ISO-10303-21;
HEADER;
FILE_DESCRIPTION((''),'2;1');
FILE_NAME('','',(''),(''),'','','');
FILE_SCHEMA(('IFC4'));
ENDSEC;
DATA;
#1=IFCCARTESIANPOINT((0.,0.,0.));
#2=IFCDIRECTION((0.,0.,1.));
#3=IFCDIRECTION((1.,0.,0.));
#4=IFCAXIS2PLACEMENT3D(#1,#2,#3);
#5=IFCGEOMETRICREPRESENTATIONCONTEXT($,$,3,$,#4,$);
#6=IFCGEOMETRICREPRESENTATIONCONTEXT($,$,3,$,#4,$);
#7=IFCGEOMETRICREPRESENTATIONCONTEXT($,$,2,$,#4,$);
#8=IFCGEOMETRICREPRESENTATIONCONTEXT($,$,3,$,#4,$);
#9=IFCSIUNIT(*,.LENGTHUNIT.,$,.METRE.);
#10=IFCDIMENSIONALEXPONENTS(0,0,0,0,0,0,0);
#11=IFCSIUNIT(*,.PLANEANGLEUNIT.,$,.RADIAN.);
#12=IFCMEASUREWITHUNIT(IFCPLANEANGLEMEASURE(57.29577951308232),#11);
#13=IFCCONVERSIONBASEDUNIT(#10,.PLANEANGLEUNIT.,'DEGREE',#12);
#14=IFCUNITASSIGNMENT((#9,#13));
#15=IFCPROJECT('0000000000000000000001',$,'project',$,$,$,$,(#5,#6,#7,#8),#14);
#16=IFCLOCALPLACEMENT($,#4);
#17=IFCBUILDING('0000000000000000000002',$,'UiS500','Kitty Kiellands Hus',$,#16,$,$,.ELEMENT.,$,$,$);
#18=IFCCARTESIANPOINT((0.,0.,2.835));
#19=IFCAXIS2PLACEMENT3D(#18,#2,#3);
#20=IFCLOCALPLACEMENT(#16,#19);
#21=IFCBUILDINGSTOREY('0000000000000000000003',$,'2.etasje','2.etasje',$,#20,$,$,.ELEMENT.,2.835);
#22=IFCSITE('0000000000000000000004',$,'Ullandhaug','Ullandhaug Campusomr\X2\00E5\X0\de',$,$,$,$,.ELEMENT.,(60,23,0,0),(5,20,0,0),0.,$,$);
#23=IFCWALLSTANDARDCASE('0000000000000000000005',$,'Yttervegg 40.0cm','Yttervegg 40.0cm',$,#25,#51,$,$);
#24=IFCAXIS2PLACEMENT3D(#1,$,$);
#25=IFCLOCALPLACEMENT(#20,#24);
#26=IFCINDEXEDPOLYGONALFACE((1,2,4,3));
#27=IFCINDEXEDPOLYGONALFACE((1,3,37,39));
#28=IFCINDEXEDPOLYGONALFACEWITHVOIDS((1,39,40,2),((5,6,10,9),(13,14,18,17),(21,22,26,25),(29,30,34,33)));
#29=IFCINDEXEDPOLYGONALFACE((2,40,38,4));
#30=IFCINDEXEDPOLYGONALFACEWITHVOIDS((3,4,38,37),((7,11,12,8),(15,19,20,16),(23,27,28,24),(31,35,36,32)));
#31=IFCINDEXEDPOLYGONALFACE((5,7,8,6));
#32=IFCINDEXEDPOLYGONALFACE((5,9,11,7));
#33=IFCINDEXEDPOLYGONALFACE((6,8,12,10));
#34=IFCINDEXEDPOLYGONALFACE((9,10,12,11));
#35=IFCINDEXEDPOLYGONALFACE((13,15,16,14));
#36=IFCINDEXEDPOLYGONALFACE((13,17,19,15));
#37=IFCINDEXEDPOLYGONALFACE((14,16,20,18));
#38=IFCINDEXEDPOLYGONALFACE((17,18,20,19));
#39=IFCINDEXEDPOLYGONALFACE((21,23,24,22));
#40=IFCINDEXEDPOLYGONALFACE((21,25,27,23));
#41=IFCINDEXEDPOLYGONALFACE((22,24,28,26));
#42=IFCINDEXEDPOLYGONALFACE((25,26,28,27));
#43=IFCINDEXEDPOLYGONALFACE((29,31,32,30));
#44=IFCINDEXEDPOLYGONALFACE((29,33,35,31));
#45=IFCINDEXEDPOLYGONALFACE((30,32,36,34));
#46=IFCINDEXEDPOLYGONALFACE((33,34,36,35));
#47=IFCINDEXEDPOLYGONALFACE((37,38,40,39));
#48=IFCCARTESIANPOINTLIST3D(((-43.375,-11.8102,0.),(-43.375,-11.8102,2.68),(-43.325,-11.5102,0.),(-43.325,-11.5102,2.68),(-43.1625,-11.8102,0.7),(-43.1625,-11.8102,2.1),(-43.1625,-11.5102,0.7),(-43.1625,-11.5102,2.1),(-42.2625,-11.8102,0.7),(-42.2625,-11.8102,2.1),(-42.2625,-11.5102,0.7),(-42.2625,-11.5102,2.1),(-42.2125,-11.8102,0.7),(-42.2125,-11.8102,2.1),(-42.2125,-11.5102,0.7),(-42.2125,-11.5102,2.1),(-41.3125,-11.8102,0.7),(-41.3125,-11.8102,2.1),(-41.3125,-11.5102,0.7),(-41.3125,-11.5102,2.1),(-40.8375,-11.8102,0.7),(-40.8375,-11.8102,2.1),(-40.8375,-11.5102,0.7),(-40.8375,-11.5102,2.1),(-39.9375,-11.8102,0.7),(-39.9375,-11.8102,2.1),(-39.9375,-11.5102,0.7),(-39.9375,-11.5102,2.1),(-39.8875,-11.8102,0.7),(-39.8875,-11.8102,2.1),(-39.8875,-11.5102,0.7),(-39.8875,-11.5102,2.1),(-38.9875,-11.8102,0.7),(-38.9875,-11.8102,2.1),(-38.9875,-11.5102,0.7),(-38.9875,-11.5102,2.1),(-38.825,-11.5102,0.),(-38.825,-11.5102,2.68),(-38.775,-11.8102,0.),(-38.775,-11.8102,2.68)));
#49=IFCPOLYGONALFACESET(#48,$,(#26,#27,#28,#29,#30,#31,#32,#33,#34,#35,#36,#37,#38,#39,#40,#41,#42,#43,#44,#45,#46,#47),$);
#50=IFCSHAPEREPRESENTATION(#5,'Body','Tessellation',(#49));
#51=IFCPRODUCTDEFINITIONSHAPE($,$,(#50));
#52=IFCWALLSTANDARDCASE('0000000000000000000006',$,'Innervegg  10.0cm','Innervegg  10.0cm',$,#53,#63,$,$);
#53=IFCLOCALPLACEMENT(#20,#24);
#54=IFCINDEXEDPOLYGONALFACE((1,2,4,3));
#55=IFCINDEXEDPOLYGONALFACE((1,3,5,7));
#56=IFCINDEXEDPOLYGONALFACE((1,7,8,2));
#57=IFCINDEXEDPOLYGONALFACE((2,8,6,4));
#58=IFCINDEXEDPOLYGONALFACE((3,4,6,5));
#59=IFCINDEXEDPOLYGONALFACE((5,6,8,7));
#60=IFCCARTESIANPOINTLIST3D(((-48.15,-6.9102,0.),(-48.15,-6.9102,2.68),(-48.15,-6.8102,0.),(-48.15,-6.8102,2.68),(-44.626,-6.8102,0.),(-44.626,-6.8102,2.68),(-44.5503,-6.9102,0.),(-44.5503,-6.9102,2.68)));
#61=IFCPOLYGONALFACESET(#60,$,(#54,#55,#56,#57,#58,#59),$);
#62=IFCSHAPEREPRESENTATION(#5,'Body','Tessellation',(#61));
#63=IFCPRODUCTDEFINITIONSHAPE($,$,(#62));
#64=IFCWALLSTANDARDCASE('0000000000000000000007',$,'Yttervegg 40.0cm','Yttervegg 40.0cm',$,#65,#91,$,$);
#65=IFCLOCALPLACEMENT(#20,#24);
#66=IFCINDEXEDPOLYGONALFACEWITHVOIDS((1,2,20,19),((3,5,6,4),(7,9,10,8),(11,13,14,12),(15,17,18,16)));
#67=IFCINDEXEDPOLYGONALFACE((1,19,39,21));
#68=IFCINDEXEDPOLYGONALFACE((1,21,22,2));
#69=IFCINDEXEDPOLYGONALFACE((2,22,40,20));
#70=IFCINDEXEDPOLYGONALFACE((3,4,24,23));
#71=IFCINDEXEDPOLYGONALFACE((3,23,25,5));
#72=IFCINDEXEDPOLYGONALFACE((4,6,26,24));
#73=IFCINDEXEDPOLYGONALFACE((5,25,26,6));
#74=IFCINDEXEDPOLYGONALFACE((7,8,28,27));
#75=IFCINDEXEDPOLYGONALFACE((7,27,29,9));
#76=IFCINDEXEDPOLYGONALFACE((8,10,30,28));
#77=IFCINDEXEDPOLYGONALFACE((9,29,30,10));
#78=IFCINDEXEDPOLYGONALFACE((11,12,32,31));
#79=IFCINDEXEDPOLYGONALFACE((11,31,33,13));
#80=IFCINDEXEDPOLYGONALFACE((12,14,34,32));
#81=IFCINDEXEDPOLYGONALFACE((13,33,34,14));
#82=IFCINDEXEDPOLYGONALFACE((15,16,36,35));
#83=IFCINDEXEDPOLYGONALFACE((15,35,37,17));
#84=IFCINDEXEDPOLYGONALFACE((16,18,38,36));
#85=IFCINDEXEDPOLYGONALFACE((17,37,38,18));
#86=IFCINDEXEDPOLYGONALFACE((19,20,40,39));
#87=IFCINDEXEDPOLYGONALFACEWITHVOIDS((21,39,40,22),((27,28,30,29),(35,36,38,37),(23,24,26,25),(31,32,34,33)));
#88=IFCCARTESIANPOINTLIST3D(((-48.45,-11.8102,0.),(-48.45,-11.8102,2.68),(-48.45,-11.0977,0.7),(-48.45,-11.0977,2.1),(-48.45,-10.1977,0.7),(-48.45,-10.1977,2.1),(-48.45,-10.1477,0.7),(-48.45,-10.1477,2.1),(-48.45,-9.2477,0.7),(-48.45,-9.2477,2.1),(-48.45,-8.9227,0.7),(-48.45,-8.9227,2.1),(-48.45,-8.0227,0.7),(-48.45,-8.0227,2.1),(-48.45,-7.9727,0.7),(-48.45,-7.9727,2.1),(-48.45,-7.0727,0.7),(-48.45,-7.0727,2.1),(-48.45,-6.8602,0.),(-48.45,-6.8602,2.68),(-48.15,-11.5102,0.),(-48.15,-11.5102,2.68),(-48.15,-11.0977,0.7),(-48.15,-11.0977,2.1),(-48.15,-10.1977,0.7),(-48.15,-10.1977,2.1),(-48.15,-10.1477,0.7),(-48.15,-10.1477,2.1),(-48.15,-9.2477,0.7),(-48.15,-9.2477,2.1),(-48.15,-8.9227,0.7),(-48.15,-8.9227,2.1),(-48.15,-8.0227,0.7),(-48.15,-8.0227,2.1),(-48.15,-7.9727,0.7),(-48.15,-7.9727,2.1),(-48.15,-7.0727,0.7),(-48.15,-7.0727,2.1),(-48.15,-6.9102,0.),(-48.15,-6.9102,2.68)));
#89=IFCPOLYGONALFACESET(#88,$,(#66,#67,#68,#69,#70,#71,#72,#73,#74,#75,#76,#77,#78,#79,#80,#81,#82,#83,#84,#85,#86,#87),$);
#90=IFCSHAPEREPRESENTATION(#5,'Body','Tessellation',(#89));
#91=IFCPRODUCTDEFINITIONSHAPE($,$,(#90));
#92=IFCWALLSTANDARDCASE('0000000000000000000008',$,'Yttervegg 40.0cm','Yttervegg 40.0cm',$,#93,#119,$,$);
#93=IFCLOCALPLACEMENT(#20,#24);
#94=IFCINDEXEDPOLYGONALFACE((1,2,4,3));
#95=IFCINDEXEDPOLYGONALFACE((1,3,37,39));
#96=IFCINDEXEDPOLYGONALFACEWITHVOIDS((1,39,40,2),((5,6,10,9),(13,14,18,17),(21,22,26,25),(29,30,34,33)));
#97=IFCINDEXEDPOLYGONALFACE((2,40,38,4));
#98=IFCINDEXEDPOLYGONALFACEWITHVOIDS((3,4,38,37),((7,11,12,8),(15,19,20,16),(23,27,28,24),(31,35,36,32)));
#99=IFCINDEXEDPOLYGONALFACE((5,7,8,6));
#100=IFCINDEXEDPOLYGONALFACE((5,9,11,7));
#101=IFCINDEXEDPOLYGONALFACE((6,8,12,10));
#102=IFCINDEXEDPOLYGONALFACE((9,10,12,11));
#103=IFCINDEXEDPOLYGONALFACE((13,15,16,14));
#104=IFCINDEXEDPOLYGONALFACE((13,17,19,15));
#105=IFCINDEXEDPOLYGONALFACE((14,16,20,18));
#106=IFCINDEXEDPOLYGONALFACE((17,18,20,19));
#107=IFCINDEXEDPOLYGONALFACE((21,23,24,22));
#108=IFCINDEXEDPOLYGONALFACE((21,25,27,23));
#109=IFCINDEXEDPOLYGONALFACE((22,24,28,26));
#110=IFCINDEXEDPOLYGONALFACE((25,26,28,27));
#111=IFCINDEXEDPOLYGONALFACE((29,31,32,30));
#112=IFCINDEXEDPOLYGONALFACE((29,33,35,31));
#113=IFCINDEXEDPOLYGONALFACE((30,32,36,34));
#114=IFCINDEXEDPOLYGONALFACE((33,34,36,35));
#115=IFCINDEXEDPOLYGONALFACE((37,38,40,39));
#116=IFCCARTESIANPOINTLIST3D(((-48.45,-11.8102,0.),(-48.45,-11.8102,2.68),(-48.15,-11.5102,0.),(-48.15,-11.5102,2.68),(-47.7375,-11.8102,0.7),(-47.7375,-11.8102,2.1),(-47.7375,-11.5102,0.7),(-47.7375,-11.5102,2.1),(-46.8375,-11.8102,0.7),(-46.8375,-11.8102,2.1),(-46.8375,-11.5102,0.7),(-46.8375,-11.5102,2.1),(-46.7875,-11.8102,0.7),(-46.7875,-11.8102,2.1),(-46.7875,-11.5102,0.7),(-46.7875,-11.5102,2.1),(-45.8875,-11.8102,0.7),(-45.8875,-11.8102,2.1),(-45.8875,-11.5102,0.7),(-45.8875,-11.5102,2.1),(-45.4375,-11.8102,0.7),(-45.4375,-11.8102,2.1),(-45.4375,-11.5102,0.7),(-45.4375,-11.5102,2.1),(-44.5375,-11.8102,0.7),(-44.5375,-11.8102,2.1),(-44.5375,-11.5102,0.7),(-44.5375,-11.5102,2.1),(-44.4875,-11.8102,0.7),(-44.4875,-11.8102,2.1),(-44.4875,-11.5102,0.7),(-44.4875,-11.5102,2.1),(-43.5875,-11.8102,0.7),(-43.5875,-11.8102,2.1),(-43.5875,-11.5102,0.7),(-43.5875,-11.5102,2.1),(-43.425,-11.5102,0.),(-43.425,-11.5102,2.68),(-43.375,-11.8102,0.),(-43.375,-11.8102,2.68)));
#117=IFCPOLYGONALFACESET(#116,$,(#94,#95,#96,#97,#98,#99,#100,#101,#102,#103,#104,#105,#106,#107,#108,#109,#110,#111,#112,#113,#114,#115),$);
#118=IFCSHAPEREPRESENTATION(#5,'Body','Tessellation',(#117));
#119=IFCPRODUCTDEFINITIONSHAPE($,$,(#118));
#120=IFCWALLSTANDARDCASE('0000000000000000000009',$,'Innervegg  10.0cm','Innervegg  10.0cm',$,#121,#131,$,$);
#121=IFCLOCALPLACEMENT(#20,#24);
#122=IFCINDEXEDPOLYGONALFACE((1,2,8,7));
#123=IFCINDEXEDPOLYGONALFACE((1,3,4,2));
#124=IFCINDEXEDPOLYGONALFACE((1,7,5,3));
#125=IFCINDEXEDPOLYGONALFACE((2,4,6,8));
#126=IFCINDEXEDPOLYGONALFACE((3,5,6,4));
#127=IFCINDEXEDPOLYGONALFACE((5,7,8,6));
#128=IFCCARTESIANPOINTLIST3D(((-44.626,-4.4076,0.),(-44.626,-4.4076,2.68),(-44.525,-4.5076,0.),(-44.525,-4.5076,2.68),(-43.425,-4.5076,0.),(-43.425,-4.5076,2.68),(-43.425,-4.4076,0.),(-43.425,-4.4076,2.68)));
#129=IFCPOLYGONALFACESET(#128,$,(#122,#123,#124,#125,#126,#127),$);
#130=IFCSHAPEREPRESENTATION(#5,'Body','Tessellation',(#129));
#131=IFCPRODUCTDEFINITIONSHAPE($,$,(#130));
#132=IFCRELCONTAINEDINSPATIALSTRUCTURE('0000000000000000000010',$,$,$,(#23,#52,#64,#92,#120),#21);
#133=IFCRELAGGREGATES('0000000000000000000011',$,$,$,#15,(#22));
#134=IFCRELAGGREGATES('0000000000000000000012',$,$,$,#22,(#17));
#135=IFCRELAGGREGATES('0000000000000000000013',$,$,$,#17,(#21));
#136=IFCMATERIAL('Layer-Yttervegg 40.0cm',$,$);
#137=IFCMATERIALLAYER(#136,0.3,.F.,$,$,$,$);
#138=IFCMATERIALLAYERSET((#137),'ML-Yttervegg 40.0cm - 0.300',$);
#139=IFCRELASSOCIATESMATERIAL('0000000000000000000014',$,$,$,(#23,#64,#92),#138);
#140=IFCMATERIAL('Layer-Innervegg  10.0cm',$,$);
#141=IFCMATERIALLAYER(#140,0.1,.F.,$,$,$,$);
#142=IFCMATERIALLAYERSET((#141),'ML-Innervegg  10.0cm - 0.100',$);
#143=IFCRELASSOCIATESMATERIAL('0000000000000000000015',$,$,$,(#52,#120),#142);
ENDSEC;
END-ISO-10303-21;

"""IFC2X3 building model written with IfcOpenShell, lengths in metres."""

from ifc_helpers import new_model, entity, si_unit, converted_unit, frame, origin_with_axes, place, context, project, spatial, polyline, outline, extrude, material, layer, layer_set, layer_usage, element, save


model = new_model("IFC2X3")

# Units and contexts
context_of_model_1 = context(None, 3, world=origin_with_axes())
context_of_model_2 = context(None, 3, world=origin_with_axes())
context_of_model_3 = context(None, 2, world=origin_with_axes())
context_of_model_4 = context(None, 3, world=origin_with_axes())
ifc_project = project(units=[si_unit("LENGTHUNIT", "METRE"), converted_unit("PLANEANGLEUNIT", "DEGREE", entity("IfcPlaneAngleMeasure", 57.29577951308232), si_unit("PLANEANGLEUNIT", "RADIAN"), dimensions=[0, 0, 0, 0, 0, 0, 0])], contexts=[context_of_model_1, context_of_model_2, context_of_model_3, context_of_model_4])

# Site, building, storey
site = spatial("IfcSite", under=ifc_project, Name="Ullandhaug", Description="Ullandhaug Campusområde", CompositionType="ELEMENT", RefLatitude=(60, 23, 0, 0), RefLongitude=(5, 20, 0, 0), RefElevation=0.0)
building_placement = place(None, origin_with_axes())
building = spatial("IfcBuilding", under=site, at=building_placement, Name="UiS500", Description="Kitty Kiellands Hus", CompositionType="ELEMENT")
storey_placement = place(building_placement, frame((0.0, 0.0, 2.835), z_axis=(0.0, 0.0, 1.0), x_axis=(1.0, 0.0, 0.0)))
storey = spatial("IfcBuildingStorey", under=building, at=storey_placement, Name="2.etasje", Description="2.etasje", CompositionType="ELEMENT", Elevation=2.835)

# Shared definitions
ifc_material_1 = material(Name="Layer-Innervegg  10.0cm")
ifc_layer_1 = layer(ifc_material_1, 0.1, ventilated=False)
ifc_layer_set_1 = layer_set([ifc_layer_1], Name="ML-Innervegg  10.0cm - 0.100")
ifc_layer_usage_1 = layer_usage(ifc_layer_set_1, "AXIS2", "POSITIVE", 0.0)

# Shared definitions
ifc_material_2 = material(Name="Layer-Yttervegg 40.0cm")
ifc_layer_2 = layer(ifc_material_2, 0.3, ventilated=False)
ifc_layer_set_2 = layer_set([ifc_layer_2], Name="ML-Yttervegg 40.0cm - 0.300")
ifc_layer_usage_2 = layer_usage(ifc_layer_set_2, "AXIS2", "POSITIVE", 0.0)

# Wall, openings
wall_1_placement = place(storey_placement, frame((-43.375, -11.8102, 0.0), z_axis=(0.0, 0.0, 1.0), x_axis=(1.0, 0.0, 0.0)))
wall_1 = element("IfcWallStandardCase", 1, at=wall_1_placement, inside=storey, material=ifc_layer_usage_2, Name="Yttervegg 40.0cm", Description="Yttervegg 40.0cm", context=context_of_model_1, shape_type="SweptSolid", body=[
    extrude(outline(polyline([(0.0, 0.0), (4.6, 0.0), (4.55, 0.3), (0.05, 0.3), (0.0, 0.0)])), origin_with_axes(), (0.0, 0.0, 1.0), 2.68),
])
opening_1_placement = place(wall_1_placement, frame((3.4875, 0.3, 0.7), z_axis=(0.0, 0.0, 1.0), x_axis=(1.0, 0.0, 0.0)))
element("IfcOpeningElement", 2, at=opening_1_placement, cuts=wall_1, context=context_of_model_1, shape_type="SweptSolid", body=[
    extrude(outline(polyline([(0.0, 0.0), (1.4, 0.0), (1.4, 0.9), (0.0, 0.9), (0.0, 0.0)])), frame((0.0, 0.0, 0.0), z_axis=(0.0, 1.0, 0.0), x_axis=(0.0, 0.0, 1.0)), (0.0, 0.0, -1.0), 0.3),
])
opening_2_placement = place(wall_1_placement, frame((2.5375, 0.3, 0.7), z_axis=(0.0, 0.0, 1.0), x_axis=(1.0, 0.0, 0.0)))
element("IfcOpeningElement", 3, at=opening_2_placement, cuts=wall_1, context=context_of_model_1, shape_type="SweptSolid", body=[
    extrude(outline(polyline([(0.0, 0.0), (1.4, 0.0), (1.4, 0.9), (0.0, 0.9), (0.0, 0.0)])), frame((0.0, 0.0, 0.0), z_axis=(0.0, 1.0, 0.0), x_axis=(0.0, 0.0, 1.0)), (0.0, 0.0, -1.0), 0.3),
])
opening_3_placement = place(wall_1_placement, frame((1.1625, 0.3, 0.7), z_axis=(0.0, 0.0, 1.0), x_axis=(1.0, 0.0, 0.0)))
element("IfcOpeningElement", 4, at=opening_3_placement, cuts=wall_1, context=context_of_model_1, shape_type="SweptSolid", body=[
    extrude(outline(polyline([(0.0, 0.0), (1.4, 0.0), (1.4, 0.9), (0.0, 0.9), (0.0, 0.0)])), frame((0.0, 0.0, 0.0), z_axis=(0.0, 1.0, 0.0), x_axis=(0.0, 0.0, 1.0)), (0.0, 0.0, -1.0), 0.3),
])
opening_4_placement = place(wall_1_placement, frame((0.2125, 0.3, 0.7), z_axis=(0.0, 0.0, 1.0), x_axis=(1.0, 0.0, 0.0)))
element("IfcOpeningElement", 5, at=opening_4_placement, cuts=wall_1, context=context_of_model_1, shape_type="SweptSolid", body=[
    extrude(outline(polyline([(0.0, 0.0), (1.4, 0.0), (1.4, 0.9), (0.0, 0.9), (0.0, 0.0)])), frame((0.0, 0.0, 0.0), z_axis=(0.0, 1.0, 0.0), x_axis=(0.0, 0.0, 1.0)), (0.0, 0.0, -1.0), 0.3),
])

# Wall
wall_2_placement = place(storey_placement, frame((-44.626, -6.8102, 0.0), z_axis=(0.0, 0.0, 1.0), x_axis=(-1.0, 0.0, 0.0)))
element("IfcWallStandardCase", 6, at=wall_2_placement, inside=storey, material=ifc_layer_usage_1, Name="Innervegg  10.0cm", Description="Innervegg  10.0cm", context=context_of_model_1, shape_type="SweptSolid", body=[
    extrude(outline(polyline([(0.0, 0.0), (3.524, 0.0), (3.524, 0.1), (-0.0758, 0.1), (0.0, 0.0)])), frame((0.0, 0.0, 0.0), z_axis=(0.0, 0.0, 1.0), x_axis=(1.0, 0.0, 0.0)), (0.0, 0.0, 1.0), 2.68),
])

# Walls, openings
wall_3_placement = place(storey_placement, frame((-48.45, -6.8602, 0.0), z_axis=(0.0, 0.0, 1.0), x_axis=(0.0, -1.0, 0.0)))
wall_3 = element("IfcWallStandardCase", 7, at=wall_3_placement, inside=storey, material=ifc_layer_usage_2, Name="Yttervegg 40.0cm", Description="Yttervegg 40.0cm", context=context_of_model_1, shape_type="SweptSolid", body=[
    extrude(outline(polyline([(0.0, 0.0), (4.95, 0.0), (4.65, 0.3), (0.05, 0.3), (0.0, 0.0)])), frame((0.0, 0.0, 0.0), z_axis=(0.0, 0.0, 1.0), x_axis=(1.0, 0.0, 0.0)), (0.0, 0.0, 1.0), 2.68),
])
opening_5_placement = place(wall_3_placement, frame((3.3375, 0.3, 0.7), z_axis=(0.0, 0.0, 1.0), x_axis=(1.0, 0.0, 0.0)))
element("IfcOpeningElement", 8, at=opening_5_placement, cuts=wall_3, context=context_of_model_1, shape_type="SweptSolid", body=[
    extrude(outline(polyline([(0.0, 0.0), (1.4, 0.0), (1.4, 0.9), (0.0, 0.9), (0.0, 0.0)])), frame((0.0, 0.0, 0.0), z_axis=(0.0, 1.0, 0.0), x_axis=(0.0, 0.0, 1.0)), (0.0, 0.0, -1.0), 0.3),
])
opening_6_placement = place(wall_3_placement, frame((2.3875, 0.3, 0.7), z_axis=(0.0, 0.0, 1.0), x_axis=(1.0, 0.0, 0.0)))
element("IfcOpeningElement", 9, at=opening_6_placement, cuts=wall_3, context=context_of_model_1, shape_type="SweptSolid", body=[
    extrude(outline(polyline([(0.0, 0.0), (1.4, 0.0), (1.4, 0.9), (0.0, 0.9), (0.0, 0.0)])), frame((0.0, 0.0, 0.0), z_axis=(0.0, 1.0, 0.0), x_axis=(0.0, 0.0, 1.0)), (0.0, 0.0, -1.0), 0.3),
])
opening_7_placement = place(wall_3_placement, frame((1.1625, 0.3, 0.7), z_axis=(0.0, 0.0, 1.0), x_axis=(1.0, 0.0, 0.0)))
element("IfcOpeningElement", 10, at=opening_7_placement, cuts=wall_3, context=context_of_model_1, shape_type="SweptSolid", body=[
    extrude(outline(polyline([(0.0, 0.0), (1.4, 0.0), (1.4, 0.9), (0.0, 0.9), (0.0, 0.0)])), frame((0.0, 0.0, 0.0), z_axis=(0.0, 1.0, 0.0), x_axis=(0.0, 0.0, 1.0)), (0.0, 0.0, -1.0), 0.3),
])
opening_8_placement = place(wall_3_placement, frame((0.2125, 0.3, 0.7), z_axis=(0.0, 0.0, 1.0), x_axis=(1.0, 0.0, 0.0)))
element("IfcOpeningElement", 11, at=opening_8_placement, cuts=wall_3, context=context_of_model_1, shape_type="SweptSolid", body=[
    extrude(outline(polyline([(0.0, 0.0), (1.4, 0.0), (1.4, 0.9), (0.0, 0.9), (0.0, 0.0)])), frame((0.0, 0.0, 0.0), z_axis=(0.0, 1.0, 0.0), x_axis=(0.0, 0.0, 1.0)), (0.0, 0.0, -1.0), 0.3),
])
wall_4_placement = place(storey_placement, frame((-48.45, -11.8102, 0.0), z_axis=(0.0, 0.0, 1.0), x_axis=(1.0, 0.0, 0.0)))
wall_4 = element("IfcWallStandardCase", 12, at=wall_4_placement, inside=storey, material=ifc_layer_usage_2, Name="Yttervegg 40.0cm", Description="Yttervegg 40.0cm", context=context_of_model_1, shape_type="SweptSolid", body=[
    extrude(outline(polyline([(0.0, 0.0), (5.075, 0.0), (5.025, 0.3), (0.3, 0.3), (0.0, 0.0)])), origin_with_axes(), (0.0, 0.0, 1.0), 2.68),
])
opening_9_placement = place(wall_4_placement, frame((3.9625, 0.3, 0.7), z_axis=(0.0, 0.0, 1.0), x_axis=(1.0, 0.0, 0.0)))
element("IfcOpeningElement", 13, at=opening_9_placement, cuts=wall_4, context=context_of_model_1, shape_type="SweptSolid", body=[
    extrude(outline(polyline([(0.0, 0.0), (1.4, 0.0), (1.4, 0.9), (0.0, 0.9), (0.0, 0.0)])), frame((0.0, 0.0, 0.0), z_axis=(0.0, 1.0, 0.0), x_axis=(0.0, 0.0, 1.0)), (0.0, 0.0, -1.0), 0.3),
])
opening_10_placement = place(wall_4_placement, frame((3.0125, 0.3, 0.7), z_axis=(0.0, 0.0, 1.0), x_axis=(1.0, 0.0, 0.0)))
element("IfcOpeningElement", 14, at=opening_10_placement, cuts=wall_4, context=context_of_model_1, shape_type="SweptSolid", body=[
    extrude(outline(polyline([(0.0, 0.0), (1.4, 0.0), (1.4, 0.9), (0.0, 0.9), (0.0, 0.0)])), frame((0.0, 0.0, 0.0), z_axis=(0.0, 1.0, 0.0), x_axis=(0.0, 0.0, 1.0)), (0.0, 0.0, -1.0), 0.3),
])
opening_11_placement = place(wall_4_placement, frame((1.6625, 0.3, 0.7), z_axis=(0.0, 0.0, 1.0), x_axis=(1.0, 0.0, 0.0)))
element("IfcOpeningElement", 15, at=opening_11_placement, cuts=wall_4, context=context_of_model_1, shape_type="SweptSolid", body=[
    extrude(outline(polyline([(0.0, 0.0), (1.4, 0.0), (1.4, 0.9), (0.0, 0.9), (0.0, 0.0)])), frame((0.0, 0.0, 0.0), z_axis=(0.0, 1.0, 0.0), x_axis=(0.0, 0.0, 1.0)), (0.0, 0.0, -1.0), 0.3),
])
opening_12_placement = place(wall_4_placement, frame((0.7125, 0.3, 0.7), z_axis=(0.0, 0.0, 1.0), x_axis=(1.0, 0.0, 0.0)))
element("IfcOpeningElement", 16, at=opening_12_placement, cuts=wall_4, context=context_of_model_1, shape_type="SweptSolid", body=[
    extrude(outline(polyline([(0.0, 0.0), (1.4, 0.0), (1.4, 0.9), (0.0, 0.9), (0.0, 0.0)])), frame((0.0, 0.0, 0.0), z_axis=(0.0, 1.0, 0.0), x_axis=(0.0, 0.0, 1.0)), (0.0, 0.0, -1.0), 0.3),
])

# Wall
wall_5_placement = place(storey_placement, frame((-44.525, -4.5076, 0.0), z_axis=(0.0, 0.0, 1.0), x_axis=(1.0, 0.0, 0.0)))
element("IfcWallStandardCase", 17, at=wall_5_placement, inside=storey, material=ifc_layer_usage_1, Name="Innervegg  10.0cm", Description="Innervegg  10.0cm", context=context_of_model_1, shape_type="SweptSolid", body=[
    extrude(outline(polyline([(0.0, 0.0), (1.1, 0.0), (1.1, 0.1), (-0.101, 0.1), (0.0, 0.0)])), origin_with_axes(), (0.0, 0.0, 1.0), 2.68),
])

save(model, "model.ifc")
